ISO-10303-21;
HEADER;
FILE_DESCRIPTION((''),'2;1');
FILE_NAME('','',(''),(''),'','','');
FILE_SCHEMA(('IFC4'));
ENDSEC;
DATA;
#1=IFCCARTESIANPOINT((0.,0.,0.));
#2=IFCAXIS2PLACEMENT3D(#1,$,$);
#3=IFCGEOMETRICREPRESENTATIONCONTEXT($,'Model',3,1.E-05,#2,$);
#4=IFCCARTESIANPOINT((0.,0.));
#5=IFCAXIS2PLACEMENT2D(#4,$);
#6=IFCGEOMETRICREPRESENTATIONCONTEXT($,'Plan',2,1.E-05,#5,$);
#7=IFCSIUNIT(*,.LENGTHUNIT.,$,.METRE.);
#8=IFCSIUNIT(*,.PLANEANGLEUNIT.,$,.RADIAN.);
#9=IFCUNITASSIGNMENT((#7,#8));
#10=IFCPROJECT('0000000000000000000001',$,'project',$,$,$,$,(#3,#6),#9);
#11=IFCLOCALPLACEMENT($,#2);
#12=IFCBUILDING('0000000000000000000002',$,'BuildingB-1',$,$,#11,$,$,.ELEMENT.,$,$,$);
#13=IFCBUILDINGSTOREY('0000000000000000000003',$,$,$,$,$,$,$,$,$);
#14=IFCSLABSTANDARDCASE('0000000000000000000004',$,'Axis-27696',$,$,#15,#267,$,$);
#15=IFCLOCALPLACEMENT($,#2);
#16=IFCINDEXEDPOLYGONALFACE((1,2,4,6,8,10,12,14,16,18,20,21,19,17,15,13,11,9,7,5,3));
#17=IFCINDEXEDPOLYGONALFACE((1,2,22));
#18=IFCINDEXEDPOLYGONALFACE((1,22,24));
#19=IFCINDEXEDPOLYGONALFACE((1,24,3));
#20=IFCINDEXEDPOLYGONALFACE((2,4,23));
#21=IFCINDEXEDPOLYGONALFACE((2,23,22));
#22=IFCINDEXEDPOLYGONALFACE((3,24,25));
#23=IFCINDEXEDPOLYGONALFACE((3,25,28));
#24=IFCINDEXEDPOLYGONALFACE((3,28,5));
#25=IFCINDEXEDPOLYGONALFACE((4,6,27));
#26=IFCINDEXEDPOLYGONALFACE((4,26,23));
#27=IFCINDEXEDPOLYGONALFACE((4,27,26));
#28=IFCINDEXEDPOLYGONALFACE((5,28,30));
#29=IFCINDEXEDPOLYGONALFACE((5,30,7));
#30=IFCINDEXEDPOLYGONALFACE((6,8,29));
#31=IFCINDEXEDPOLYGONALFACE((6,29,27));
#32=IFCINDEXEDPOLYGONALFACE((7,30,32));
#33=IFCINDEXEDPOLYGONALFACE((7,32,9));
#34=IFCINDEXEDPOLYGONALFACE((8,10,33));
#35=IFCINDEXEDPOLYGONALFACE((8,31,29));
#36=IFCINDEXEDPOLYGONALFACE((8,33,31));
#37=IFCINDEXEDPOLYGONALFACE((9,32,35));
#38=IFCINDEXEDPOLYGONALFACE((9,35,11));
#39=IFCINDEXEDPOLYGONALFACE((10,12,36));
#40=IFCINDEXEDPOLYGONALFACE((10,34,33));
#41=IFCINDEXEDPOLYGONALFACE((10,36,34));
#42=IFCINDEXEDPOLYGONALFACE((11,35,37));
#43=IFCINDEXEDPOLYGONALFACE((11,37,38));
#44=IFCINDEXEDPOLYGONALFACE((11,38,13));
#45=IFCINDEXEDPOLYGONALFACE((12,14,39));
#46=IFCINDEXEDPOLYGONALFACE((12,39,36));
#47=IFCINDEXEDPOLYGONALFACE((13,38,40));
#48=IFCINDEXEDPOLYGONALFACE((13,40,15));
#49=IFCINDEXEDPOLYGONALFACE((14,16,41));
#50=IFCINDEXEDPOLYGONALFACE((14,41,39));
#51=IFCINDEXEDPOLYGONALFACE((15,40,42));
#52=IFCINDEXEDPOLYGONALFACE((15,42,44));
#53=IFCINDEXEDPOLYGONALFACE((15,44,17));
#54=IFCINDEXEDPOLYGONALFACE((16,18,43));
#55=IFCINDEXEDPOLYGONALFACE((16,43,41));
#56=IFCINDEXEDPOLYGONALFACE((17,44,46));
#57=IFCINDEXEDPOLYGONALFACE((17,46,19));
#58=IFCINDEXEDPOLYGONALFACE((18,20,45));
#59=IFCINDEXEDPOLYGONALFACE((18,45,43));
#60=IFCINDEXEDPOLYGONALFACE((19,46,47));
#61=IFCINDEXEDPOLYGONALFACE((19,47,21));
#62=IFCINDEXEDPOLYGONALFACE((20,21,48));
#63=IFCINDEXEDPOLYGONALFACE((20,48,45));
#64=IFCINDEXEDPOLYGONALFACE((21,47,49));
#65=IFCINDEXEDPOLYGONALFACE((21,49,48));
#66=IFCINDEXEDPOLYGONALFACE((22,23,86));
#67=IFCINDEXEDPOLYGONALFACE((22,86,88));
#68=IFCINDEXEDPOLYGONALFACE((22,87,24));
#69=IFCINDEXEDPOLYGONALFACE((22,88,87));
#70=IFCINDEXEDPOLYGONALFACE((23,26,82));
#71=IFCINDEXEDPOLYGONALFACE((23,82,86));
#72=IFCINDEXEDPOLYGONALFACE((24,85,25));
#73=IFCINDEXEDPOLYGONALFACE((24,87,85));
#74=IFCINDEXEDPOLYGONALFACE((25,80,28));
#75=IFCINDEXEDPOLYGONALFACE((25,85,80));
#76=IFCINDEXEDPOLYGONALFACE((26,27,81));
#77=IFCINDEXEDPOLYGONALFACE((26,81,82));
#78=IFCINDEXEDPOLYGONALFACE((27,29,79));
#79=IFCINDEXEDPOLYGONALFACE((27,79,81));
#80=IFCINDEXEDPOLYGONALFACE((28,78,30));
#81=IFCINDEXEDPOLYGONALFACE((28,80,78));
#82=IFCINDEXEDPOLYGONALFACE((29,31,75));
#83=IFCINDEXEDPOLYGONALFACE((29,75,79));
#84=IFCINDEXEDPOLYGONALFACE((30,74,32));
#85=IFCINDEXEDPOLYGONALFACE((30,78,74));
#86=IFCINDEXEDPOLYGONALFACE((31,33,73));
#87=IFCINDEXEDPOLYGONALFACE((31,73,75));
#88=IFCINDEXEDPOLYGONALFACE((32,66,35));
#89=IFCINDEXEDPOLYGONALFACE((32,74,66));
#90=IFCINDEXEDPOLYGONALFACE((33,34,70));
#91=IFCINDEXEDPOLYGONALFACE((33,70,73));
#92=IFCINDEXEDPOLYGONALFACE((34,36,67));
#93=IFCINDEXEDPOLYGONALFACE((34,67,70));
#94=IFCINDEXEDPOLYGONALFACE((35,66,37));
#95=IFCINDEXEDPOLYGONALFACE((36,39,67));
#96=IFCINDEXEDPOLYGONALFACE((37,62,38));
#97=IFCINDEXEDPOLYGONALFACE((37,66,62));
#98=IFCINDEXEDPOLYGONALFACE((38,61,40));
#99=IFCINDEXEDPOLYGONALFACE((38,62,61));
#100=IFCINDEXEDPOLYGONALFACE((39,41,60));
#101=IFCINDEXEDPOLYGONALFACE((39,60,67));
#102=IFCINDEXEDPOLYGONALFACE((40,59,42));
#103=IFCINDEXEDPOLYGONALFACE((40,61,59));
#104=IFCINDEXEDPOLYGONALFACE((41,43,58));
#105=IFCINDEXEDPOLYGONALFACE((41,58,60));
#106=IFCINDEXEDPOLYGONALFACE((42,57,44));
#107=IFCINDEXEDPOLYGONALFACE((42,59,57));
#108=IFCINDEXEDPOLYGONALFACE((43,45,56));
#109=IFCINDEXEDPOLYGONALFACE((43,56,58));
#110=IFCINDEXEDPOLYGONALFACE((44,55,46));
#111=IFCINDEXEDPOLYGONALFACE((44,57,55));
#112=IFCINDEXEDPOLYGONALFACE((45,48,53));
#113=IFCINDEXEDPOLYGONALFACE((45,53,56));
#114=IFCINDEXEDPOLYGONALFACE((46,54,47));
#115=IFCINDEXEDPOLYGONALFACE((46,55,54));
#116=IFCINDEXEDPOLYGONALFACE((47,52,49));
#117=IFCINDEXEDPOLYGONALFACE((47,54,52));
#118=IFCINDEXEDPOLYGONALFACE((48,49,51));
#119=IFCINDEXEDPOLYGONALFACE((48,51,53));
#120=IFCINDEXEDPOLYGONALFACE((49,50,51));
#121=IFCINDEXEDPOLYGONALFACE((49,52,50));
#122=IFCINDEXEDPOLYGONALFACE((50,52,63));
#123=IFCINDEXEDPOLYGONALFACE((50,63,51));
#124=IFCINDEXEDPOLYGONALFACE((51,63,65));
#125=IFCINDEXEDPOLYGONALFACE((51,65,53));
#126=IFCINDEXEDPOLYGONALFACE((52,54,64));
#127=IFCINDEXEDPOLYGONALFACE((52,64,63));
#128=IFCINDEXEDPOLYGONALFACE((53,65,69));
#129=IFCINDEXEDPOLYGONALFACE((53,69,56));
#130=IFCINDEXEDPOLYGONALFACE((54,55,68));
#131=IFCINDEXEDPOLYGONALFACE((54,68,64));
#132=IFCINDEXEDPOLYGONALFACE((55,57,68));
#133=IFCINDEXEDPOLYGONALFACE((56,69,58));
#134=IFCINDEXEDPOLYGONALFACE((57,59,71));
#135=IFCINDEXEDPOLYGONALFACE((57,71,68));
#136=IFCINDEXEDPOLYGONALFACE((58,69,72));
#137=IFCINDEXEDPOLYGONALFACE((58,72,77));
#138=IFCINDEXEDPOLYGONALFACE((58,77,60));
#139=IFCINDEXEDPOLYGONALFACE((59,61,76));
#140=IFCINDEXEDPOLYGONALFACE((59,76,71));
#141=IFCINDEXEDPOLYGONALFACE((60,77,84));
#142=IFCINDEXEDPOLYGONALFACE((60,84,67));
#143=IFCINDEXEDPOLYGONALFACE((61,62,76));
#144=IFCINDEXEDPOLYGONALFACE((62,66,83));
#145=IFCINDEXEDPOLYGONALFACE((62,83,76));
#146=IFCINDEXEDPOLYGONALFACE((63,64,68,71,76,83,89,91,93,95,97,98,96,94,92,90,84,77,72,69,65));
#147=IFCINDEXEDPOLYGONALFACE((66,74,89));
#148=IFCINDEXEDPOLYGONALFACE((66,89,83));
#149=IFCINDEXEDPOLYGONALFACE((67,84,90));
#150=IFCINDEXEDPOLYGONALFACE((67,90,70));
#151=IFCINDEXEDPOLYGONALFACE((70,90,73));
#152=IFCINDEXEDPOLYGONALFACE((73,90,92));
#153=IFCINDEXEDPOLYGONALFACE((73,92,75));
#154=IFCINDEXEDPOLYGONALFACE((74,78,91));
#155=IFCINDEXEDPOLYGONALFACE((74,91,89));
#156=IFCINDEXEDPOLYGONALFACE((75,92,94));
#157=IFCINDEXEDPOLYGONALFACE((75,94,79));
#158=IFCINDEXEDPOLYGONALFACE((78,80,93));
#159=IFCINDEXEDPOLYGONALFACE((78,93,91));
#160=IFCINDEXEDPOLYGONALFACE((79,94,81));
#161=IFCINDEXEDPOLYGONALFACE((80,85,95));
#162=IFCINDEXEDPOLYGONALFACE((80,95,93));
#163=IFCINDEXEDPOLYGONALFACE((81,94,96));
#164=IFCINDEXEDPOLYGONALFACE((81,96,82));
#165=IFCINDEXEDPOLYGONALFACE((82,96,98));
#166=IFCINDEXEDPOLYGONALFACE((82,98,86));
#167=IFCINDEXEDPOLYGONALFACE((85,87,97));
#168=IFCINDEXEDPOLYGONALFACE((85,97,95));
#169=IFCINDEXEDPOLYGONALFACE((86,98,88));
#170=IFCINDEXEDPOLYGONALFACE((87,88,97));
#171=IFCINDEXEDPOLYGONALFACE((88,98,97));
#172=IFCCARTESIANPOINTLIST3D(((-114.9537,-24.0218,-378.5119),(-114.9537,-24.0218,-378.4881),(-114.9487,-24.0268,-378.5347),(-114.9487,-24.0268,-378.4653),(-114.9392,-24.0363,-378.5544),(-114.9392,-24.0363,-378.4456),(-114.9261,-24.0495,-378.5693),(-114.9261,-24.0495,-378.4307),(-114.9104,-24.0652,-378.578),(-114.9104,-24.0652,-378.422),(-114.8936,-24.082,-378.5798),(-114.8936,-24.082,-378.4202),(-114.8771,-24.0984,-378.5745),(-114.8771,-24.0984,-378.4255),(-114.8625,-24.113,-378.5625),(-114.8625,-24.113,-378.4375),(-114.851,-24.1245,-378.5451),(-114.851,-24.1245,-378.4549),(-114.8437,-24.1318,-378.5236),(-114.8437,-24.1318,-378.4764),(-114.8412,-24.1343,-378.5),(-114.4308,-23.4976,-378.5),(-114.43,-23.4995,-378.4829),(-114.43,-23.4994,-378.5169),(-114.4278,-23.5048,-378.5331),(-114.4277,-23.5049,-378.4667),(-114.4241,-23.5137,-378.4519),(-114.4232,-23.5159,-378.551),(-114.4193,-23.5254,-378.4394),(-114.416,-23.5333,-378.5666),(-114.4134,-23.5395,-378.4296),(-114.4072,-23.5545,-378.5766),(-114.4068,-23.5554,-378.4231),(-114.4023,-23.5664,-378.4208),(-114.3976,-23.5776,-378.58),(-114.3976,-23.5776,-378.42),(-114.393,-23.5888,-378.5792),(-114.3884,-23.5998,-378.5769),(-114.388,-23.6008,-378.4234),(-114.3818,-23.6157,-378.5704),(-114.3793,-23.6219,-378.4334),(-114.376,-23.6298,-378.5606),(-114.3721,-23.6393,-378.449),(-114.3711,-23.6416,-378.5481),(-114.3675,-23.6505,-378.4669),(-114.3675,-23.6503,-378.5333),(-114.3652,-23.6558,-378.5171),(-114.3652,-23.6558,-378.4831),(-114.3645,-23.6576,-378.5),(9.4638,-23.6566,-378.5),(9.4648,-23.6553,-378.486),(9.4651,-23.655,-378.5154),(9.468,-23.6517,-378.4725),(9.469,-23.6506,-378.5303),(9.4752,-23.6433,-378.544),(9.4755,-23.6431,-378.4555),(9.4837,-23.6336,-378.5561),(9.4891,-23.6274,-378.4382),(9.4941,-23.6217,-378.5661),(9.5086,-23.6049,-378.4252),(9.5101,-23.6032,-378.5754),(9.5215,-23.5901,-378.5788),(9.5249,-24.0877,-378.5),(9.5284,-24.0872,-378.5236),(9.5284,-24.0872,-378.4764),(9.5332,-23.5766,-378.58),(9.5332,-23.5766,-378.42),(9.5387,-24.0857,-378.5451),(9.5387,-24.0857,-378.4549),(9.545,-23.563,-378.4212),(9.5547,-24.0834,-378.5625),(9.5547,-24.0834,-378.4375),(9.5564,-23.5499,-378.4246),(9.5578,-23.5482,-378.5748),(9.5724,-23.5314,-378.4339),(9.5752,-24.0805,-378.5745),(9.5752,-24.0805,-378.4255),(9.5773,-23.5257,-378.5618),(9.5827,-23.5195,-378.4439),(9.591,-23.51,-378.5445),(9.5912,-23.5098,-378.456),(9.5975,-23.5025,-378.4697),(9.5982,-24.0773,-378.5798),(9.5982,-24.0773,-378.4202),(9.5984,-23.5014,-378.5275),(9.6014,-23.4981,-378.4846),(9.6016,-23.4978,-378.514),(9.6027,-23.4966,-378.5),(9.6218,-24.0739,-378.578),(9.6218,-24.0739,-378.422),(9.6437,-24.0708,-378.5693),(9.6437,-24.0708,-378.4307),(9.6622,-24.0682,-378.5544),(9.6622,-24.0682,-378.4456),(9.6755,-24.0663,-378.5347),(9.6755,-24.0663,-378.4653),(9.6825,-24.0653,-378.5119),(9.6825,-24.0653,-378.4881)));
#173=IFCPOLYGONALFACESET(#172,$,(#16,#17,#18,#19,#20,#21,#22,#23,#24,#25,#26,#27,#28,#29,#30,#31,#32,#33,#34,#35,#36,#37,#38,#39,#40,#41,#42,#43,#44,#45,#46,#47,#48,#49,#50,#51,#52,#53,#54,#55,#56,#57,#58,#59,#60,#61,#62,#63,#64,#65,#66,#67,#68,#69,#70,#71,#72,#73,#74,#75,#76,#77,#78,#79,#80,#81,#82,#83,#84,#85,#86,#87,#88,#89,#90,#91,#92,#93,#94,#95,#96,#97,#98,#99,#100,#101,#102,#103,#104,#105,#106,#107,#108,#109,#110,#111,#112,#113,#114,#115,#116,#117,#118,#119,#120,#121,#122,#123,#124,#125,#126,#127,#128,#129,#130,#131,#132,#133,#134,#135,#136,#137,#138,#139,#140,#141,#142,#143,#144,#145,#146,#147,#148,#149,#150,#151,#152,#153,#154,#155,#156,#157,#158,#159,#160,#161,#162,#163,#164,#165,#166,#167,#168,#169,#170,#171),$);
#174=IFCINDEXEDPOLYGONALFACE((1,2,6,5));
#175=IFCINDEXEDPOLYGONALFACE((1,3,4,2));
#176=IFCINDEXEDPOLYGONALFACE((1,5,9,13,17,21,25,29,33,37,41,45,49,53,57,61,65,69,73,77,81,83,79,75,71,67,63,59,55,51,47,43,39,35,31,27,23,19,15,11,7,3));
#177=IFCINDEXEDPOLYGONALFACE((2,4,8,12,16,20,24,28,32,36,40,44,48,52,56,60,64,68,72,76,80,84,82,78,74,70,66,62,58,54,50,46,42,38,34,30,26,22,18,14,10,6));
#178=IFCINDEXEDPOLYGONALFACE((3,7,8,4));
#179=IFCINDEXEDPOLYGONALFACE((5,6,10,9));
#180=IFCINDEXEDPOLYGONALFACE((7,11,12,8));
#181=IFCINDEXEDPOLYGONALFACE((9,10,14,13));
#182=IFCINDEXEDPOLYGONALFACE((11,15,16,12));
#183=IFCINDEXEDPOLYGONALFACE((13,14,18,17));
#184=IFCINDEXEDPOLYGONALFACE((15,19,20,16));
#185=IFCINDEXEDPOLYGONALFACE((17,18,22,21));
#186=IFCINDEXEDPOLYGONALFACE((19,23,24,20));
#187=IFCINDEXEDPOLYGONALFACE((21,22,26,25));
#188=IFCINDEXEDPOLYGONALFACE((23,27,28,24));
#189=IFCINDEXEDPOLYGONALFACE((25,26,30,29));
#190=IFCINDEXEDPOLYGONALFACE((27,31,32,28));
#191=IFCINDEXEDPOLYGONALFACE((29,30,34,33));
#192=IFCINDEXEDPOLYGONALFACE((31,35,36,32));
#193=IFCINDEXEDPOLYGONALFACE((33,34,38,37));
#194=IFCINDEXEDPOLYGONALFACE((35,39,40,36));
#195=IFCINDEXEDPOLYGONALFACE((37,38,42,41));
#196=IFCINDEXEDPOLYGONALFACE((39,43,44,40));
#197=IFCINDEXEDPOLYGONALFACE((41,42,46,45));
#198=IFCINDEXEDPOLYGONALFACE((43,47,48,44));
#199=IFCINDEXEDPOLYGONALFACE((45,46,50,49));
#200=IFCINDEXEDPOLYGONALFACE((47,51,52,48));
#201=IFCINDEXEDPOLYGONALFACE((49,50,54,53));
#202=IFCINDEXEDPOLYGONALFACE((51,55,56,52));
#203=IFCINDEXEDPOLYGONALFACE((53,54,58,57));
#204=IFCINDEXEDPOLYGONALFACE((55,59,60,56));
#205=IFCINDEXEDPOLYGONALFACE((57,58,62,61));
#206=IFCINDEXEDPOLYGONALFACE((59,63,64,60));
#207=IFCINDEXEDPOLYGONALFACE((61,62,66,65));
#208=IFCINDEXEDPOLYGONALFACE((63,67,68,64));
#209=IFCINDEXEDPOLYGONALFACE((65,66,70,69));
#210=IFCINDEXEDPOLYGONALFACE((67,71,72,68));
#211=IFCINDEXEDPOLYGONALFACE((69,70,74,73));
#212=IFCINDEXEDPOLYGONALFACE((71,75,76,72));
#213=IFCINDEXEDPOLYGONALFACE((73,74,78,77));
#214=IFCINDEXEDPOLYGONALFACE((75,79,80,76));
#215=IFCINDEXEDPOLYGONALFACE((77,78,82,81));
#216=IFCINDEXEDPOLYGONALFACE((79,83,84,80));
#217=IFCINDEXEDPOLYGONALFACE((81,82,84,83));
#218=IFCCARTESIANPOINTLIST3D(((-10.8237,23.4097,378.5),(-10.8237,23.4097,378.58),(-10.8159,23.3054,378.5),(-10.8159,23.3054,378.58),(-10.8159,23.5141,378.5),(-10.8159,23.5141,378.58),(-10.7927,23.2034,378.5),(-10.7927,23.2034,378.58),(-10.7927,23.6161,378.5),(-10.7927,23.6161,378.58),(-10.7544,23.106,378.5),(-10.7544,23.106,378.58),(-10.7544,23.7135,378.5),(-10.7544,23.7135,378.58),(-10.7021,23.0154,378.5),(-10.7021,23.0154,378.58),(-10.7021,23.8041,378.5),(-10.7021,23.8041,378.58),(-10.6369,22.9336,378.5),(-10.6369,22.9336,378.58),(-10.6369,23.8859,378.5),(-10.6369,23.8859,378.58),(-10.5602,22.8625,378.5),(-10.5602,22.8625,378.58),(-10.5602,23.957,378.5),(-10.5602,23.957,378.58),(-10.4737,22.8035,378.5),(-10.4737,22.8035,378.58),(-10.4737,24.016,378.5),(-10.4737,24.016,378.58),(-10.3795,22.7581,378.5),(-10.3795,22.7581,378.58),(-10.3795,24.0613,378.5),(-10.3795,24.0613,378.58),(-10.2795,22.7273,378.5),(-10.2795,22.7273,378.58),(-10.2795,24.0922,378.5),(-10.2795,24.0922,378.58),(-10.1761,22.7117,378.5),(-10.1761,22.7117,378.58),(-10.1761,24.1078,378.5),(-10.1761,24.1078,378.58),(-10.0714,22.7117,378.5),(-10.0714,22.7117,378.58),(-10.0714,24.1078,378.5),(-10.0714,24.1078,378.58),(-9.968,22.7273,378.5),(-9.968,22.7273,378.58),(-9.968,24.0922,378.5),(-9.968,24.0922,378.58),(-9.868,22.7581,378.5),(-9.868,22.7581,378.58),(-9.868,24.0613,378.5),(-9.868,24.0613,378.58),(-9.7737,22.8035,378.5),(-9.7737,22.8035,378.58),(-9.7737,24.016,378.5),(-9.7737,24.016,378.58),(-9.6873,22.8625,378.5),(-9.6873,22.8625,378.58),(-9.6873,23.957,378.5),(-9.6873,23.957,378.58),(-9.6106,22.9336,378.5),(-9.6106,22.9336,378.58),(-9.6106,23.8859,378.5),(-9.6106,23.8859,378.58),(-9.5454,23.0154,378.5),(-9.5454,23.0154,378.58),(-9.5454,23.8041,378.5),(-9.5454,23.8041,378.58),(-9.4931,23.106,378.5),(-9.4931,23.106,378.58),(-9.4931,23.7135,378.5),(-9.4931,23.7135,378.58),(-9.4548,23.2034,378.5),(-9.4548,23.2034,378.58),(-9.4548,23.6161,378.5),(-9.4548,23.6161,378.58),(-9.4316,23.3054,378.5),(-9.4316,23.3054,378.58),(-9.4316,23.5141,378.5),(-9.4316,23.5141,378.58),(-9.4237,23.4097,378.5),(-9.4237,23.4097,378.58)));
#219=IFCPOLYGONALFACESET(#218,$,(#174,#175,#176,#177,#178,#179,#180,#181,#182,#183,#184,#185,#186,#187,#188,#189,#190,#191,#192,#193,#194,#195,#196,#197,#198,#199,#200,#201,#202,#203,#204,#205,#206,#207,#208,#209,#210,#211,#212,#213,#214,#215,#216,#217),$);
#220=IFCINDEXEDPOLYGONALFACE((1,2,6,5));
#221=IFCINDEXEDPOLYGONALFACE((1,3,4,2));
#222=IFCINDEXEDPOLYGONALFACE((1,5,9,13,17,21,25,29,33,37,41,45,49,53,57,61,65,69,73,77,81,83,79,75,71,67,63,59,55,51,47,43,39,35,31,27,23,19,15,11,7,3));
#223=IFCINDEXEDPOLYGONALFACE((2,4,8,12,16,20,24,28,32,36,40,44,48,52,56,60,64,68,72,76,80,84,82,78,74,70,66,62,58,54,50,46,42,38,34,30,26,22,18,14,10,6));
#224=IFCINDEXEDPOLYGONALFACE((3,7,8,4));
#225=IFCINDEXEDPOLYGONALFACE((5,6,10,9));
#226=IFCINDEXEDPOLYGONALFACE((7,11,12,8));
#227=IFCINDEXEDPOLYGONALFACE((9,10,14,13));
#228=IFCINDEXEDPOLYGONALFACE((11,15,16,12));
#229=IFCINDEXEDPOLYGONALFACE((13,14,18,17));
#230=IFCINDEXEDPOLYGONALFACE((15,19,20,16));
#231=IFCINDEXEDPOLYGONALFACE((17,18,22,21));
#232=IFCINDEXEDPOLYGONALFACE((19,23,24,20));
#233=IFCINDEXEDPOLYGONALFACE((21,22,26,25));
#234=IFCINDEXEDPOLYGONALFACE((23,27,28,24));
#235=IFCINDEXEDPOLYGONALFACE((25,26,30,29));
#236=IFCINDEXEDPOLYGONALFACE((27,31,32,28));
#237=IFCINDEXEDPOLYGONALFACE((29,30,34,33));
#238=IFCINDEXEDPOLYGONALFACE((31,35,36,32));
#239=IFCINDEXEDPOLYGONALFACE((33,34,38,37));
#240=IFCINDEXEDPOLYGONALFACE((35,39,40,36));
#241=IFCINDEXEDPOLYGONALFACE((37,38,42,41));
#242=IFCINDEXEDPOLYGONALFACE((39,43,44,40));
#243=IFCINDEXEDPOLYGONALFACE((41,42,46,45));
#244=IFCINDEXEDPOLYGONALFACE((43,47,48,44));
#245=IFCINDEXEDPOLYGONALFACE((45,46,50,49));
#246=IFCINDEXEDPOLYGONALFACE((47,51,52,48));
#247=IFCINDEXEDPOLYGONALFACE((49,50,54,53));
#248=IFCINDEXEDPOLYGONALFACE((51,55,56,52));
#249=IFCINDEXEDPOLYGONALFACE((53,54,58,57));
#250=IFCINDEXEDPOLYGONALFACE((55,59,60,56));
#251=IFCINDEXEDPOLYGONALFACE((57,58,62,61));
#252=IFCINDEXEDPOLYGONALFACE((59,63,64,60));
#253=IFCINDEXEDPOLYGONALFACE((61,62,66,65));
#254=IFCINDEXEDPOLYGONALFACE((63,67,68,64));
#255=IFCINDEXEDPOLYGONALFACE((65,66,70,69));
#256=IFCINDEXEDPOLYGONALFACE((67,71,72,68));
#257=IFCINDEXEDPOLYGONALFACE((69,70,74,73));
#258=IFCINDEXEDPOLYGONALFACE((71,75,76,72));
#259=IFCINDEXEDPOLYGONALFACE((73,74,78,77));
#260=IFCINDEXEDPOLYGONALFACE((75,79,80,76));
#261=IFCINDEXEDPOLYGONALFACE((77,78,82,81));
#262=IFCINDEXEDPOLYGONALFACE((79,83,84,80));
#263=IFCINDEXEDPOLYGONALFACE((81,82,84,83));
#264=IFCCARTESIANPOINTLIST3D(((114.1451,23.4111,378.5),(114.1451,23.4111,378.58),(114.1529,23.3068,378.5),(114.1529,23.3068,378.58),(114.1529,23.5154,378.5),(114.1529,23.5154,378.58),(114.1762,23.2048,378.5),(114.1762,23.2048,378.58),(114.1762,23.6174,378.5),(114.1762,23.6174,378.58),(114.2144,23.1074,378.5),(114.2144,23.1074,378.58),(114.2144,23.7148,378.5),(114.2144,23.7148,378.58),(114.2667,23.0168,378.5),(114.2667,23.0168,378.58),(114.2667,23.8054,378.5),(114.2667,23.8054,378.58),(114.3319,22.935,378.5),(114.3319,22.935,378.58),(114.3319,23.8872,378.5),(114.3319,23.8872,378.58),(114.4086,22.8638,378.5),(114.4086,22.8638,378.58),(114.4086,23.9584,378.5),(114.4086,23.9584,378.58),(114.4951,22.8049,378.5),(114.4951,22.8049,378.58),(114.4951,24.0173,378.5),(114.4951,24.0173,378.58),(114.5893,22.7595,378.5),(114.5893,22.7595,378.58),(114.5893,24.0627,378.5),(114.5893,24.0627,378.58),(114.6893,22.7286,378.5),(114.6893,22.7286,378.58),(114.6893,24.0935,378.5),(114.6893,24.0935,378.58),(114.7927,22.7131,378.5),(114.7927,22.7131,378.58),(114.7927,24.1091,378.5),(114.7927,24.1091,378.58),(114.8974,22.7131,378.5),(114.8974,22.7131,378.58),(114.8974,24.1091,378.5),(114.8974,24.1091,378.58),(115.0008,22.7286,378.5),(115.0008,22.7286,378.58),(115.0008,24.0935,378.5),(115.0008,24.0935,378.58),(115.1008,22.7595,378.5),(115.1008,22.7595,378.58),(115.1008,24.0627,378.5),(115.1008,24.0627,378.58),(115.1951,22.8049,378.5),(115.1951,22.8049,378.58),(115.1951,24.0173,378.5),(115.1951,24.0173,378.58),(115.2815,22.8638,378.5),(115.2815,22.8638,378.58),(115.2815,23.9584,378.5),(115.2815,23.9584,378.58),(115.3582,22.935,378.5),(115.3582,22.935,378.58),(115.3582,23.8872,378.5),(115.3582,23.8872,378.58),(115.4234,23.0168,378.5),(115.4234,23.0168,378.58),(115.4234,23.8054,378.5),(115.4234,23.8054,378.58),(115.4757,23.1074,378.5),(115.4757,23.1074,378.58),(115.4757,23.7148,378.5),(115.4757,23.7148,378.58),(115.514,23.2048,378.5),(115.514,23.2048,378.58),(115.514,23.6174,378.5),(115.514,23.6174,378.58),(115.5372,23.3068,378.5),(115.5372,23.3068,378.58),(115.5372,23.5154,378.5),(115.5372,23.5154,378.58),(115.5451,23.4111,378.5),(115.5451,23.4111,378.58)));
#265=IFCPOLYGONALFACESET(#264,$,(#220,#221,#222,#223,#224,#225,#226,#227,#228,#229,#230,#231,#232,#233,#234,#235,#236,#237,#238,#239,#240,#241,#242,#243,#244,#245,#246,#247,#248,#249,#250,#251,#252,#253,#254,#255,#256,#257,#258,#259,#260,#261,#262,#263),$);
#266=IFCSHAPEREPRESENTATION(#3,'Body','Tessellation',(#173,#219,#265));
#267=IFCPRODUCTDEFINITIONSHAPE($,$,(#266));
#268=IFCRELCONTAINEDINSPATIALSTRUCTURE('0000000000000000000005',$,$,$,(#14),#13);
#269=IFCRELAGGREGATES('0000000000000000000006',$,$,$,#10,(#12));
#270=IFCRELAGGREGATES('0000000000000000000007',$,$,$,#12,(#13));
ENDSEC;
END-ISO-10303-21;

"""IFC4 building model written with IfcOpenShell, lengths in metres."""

from ifc_helpers import new_model, entity, si_unit, frame, origin, origin_2d, place, context, project, spatial, circle, extrude, element, save


model = new_model("IFC4")

# Units and contexts
model_context = context("Model", 3, precision=1e-05, world=origin())
plan_context = context("Plan", 2, precision=1e-05, world=origin_2d())
ifc_project = project(units=[si_unit("LENGTHUNIT", "METRE"), si_unit("PLANEANGLEUNIT", "RADIAN")], contexts=[model_context, plan_context])

# Building, storey
building_placement = place(None, origin())
building = spatial("IfcBuilding", under=ifc_project, at=building_placement, Name="BuildingB-1", CompositionType="ELEMENT")
storey = spatial("IfcBuildingStorey", under=building)

# Slab
element("IfcSlabStandardCase", 1, inside=storey, Name="Axis-27696", context=model_context, shape_type="AdvancedSweptSolid", body=[
    entity("IfcSurfaceCurveSweptAreaSolid", entity("IfcCircleProfileDef", "AREA", None, None, 0.08), None, entity("IfcPolyline", [entity("IfcCartesianPoint", [-9.8903, 23.4097, 378.5]), entity("IfcCartesianPoint", [-9.3901, 23.9099, 378.5]), entity("IfcCartesianPoint", [114.5407, 23.911, 378.5]), entity("IfcCartesianPoint", [114.6116, 23.4111, 378.5])]), None, None, entity("IfcPlane", entity("IfcAxis2Placement3D", entity("IfcCartesianPoint", [-9.8903, 23.4097, 378.5]), entity("IfcDirection", [0.0, 0.0, 1.0]), entity("IfcDirection", [1.0, 0.0, 0.0])))),
    extrude(circle(Radius=0.7), frame((-10.1237, 23.4097, 378.5)), (0.0, 0.0, 1.0), 0.08),
    extrude(circle(Radius=0.7), frame((114.8451, 23.4111, 378.5)), (0.0, 0.0, 1.0), 0.08),
])

save(model, "model.ifc")
